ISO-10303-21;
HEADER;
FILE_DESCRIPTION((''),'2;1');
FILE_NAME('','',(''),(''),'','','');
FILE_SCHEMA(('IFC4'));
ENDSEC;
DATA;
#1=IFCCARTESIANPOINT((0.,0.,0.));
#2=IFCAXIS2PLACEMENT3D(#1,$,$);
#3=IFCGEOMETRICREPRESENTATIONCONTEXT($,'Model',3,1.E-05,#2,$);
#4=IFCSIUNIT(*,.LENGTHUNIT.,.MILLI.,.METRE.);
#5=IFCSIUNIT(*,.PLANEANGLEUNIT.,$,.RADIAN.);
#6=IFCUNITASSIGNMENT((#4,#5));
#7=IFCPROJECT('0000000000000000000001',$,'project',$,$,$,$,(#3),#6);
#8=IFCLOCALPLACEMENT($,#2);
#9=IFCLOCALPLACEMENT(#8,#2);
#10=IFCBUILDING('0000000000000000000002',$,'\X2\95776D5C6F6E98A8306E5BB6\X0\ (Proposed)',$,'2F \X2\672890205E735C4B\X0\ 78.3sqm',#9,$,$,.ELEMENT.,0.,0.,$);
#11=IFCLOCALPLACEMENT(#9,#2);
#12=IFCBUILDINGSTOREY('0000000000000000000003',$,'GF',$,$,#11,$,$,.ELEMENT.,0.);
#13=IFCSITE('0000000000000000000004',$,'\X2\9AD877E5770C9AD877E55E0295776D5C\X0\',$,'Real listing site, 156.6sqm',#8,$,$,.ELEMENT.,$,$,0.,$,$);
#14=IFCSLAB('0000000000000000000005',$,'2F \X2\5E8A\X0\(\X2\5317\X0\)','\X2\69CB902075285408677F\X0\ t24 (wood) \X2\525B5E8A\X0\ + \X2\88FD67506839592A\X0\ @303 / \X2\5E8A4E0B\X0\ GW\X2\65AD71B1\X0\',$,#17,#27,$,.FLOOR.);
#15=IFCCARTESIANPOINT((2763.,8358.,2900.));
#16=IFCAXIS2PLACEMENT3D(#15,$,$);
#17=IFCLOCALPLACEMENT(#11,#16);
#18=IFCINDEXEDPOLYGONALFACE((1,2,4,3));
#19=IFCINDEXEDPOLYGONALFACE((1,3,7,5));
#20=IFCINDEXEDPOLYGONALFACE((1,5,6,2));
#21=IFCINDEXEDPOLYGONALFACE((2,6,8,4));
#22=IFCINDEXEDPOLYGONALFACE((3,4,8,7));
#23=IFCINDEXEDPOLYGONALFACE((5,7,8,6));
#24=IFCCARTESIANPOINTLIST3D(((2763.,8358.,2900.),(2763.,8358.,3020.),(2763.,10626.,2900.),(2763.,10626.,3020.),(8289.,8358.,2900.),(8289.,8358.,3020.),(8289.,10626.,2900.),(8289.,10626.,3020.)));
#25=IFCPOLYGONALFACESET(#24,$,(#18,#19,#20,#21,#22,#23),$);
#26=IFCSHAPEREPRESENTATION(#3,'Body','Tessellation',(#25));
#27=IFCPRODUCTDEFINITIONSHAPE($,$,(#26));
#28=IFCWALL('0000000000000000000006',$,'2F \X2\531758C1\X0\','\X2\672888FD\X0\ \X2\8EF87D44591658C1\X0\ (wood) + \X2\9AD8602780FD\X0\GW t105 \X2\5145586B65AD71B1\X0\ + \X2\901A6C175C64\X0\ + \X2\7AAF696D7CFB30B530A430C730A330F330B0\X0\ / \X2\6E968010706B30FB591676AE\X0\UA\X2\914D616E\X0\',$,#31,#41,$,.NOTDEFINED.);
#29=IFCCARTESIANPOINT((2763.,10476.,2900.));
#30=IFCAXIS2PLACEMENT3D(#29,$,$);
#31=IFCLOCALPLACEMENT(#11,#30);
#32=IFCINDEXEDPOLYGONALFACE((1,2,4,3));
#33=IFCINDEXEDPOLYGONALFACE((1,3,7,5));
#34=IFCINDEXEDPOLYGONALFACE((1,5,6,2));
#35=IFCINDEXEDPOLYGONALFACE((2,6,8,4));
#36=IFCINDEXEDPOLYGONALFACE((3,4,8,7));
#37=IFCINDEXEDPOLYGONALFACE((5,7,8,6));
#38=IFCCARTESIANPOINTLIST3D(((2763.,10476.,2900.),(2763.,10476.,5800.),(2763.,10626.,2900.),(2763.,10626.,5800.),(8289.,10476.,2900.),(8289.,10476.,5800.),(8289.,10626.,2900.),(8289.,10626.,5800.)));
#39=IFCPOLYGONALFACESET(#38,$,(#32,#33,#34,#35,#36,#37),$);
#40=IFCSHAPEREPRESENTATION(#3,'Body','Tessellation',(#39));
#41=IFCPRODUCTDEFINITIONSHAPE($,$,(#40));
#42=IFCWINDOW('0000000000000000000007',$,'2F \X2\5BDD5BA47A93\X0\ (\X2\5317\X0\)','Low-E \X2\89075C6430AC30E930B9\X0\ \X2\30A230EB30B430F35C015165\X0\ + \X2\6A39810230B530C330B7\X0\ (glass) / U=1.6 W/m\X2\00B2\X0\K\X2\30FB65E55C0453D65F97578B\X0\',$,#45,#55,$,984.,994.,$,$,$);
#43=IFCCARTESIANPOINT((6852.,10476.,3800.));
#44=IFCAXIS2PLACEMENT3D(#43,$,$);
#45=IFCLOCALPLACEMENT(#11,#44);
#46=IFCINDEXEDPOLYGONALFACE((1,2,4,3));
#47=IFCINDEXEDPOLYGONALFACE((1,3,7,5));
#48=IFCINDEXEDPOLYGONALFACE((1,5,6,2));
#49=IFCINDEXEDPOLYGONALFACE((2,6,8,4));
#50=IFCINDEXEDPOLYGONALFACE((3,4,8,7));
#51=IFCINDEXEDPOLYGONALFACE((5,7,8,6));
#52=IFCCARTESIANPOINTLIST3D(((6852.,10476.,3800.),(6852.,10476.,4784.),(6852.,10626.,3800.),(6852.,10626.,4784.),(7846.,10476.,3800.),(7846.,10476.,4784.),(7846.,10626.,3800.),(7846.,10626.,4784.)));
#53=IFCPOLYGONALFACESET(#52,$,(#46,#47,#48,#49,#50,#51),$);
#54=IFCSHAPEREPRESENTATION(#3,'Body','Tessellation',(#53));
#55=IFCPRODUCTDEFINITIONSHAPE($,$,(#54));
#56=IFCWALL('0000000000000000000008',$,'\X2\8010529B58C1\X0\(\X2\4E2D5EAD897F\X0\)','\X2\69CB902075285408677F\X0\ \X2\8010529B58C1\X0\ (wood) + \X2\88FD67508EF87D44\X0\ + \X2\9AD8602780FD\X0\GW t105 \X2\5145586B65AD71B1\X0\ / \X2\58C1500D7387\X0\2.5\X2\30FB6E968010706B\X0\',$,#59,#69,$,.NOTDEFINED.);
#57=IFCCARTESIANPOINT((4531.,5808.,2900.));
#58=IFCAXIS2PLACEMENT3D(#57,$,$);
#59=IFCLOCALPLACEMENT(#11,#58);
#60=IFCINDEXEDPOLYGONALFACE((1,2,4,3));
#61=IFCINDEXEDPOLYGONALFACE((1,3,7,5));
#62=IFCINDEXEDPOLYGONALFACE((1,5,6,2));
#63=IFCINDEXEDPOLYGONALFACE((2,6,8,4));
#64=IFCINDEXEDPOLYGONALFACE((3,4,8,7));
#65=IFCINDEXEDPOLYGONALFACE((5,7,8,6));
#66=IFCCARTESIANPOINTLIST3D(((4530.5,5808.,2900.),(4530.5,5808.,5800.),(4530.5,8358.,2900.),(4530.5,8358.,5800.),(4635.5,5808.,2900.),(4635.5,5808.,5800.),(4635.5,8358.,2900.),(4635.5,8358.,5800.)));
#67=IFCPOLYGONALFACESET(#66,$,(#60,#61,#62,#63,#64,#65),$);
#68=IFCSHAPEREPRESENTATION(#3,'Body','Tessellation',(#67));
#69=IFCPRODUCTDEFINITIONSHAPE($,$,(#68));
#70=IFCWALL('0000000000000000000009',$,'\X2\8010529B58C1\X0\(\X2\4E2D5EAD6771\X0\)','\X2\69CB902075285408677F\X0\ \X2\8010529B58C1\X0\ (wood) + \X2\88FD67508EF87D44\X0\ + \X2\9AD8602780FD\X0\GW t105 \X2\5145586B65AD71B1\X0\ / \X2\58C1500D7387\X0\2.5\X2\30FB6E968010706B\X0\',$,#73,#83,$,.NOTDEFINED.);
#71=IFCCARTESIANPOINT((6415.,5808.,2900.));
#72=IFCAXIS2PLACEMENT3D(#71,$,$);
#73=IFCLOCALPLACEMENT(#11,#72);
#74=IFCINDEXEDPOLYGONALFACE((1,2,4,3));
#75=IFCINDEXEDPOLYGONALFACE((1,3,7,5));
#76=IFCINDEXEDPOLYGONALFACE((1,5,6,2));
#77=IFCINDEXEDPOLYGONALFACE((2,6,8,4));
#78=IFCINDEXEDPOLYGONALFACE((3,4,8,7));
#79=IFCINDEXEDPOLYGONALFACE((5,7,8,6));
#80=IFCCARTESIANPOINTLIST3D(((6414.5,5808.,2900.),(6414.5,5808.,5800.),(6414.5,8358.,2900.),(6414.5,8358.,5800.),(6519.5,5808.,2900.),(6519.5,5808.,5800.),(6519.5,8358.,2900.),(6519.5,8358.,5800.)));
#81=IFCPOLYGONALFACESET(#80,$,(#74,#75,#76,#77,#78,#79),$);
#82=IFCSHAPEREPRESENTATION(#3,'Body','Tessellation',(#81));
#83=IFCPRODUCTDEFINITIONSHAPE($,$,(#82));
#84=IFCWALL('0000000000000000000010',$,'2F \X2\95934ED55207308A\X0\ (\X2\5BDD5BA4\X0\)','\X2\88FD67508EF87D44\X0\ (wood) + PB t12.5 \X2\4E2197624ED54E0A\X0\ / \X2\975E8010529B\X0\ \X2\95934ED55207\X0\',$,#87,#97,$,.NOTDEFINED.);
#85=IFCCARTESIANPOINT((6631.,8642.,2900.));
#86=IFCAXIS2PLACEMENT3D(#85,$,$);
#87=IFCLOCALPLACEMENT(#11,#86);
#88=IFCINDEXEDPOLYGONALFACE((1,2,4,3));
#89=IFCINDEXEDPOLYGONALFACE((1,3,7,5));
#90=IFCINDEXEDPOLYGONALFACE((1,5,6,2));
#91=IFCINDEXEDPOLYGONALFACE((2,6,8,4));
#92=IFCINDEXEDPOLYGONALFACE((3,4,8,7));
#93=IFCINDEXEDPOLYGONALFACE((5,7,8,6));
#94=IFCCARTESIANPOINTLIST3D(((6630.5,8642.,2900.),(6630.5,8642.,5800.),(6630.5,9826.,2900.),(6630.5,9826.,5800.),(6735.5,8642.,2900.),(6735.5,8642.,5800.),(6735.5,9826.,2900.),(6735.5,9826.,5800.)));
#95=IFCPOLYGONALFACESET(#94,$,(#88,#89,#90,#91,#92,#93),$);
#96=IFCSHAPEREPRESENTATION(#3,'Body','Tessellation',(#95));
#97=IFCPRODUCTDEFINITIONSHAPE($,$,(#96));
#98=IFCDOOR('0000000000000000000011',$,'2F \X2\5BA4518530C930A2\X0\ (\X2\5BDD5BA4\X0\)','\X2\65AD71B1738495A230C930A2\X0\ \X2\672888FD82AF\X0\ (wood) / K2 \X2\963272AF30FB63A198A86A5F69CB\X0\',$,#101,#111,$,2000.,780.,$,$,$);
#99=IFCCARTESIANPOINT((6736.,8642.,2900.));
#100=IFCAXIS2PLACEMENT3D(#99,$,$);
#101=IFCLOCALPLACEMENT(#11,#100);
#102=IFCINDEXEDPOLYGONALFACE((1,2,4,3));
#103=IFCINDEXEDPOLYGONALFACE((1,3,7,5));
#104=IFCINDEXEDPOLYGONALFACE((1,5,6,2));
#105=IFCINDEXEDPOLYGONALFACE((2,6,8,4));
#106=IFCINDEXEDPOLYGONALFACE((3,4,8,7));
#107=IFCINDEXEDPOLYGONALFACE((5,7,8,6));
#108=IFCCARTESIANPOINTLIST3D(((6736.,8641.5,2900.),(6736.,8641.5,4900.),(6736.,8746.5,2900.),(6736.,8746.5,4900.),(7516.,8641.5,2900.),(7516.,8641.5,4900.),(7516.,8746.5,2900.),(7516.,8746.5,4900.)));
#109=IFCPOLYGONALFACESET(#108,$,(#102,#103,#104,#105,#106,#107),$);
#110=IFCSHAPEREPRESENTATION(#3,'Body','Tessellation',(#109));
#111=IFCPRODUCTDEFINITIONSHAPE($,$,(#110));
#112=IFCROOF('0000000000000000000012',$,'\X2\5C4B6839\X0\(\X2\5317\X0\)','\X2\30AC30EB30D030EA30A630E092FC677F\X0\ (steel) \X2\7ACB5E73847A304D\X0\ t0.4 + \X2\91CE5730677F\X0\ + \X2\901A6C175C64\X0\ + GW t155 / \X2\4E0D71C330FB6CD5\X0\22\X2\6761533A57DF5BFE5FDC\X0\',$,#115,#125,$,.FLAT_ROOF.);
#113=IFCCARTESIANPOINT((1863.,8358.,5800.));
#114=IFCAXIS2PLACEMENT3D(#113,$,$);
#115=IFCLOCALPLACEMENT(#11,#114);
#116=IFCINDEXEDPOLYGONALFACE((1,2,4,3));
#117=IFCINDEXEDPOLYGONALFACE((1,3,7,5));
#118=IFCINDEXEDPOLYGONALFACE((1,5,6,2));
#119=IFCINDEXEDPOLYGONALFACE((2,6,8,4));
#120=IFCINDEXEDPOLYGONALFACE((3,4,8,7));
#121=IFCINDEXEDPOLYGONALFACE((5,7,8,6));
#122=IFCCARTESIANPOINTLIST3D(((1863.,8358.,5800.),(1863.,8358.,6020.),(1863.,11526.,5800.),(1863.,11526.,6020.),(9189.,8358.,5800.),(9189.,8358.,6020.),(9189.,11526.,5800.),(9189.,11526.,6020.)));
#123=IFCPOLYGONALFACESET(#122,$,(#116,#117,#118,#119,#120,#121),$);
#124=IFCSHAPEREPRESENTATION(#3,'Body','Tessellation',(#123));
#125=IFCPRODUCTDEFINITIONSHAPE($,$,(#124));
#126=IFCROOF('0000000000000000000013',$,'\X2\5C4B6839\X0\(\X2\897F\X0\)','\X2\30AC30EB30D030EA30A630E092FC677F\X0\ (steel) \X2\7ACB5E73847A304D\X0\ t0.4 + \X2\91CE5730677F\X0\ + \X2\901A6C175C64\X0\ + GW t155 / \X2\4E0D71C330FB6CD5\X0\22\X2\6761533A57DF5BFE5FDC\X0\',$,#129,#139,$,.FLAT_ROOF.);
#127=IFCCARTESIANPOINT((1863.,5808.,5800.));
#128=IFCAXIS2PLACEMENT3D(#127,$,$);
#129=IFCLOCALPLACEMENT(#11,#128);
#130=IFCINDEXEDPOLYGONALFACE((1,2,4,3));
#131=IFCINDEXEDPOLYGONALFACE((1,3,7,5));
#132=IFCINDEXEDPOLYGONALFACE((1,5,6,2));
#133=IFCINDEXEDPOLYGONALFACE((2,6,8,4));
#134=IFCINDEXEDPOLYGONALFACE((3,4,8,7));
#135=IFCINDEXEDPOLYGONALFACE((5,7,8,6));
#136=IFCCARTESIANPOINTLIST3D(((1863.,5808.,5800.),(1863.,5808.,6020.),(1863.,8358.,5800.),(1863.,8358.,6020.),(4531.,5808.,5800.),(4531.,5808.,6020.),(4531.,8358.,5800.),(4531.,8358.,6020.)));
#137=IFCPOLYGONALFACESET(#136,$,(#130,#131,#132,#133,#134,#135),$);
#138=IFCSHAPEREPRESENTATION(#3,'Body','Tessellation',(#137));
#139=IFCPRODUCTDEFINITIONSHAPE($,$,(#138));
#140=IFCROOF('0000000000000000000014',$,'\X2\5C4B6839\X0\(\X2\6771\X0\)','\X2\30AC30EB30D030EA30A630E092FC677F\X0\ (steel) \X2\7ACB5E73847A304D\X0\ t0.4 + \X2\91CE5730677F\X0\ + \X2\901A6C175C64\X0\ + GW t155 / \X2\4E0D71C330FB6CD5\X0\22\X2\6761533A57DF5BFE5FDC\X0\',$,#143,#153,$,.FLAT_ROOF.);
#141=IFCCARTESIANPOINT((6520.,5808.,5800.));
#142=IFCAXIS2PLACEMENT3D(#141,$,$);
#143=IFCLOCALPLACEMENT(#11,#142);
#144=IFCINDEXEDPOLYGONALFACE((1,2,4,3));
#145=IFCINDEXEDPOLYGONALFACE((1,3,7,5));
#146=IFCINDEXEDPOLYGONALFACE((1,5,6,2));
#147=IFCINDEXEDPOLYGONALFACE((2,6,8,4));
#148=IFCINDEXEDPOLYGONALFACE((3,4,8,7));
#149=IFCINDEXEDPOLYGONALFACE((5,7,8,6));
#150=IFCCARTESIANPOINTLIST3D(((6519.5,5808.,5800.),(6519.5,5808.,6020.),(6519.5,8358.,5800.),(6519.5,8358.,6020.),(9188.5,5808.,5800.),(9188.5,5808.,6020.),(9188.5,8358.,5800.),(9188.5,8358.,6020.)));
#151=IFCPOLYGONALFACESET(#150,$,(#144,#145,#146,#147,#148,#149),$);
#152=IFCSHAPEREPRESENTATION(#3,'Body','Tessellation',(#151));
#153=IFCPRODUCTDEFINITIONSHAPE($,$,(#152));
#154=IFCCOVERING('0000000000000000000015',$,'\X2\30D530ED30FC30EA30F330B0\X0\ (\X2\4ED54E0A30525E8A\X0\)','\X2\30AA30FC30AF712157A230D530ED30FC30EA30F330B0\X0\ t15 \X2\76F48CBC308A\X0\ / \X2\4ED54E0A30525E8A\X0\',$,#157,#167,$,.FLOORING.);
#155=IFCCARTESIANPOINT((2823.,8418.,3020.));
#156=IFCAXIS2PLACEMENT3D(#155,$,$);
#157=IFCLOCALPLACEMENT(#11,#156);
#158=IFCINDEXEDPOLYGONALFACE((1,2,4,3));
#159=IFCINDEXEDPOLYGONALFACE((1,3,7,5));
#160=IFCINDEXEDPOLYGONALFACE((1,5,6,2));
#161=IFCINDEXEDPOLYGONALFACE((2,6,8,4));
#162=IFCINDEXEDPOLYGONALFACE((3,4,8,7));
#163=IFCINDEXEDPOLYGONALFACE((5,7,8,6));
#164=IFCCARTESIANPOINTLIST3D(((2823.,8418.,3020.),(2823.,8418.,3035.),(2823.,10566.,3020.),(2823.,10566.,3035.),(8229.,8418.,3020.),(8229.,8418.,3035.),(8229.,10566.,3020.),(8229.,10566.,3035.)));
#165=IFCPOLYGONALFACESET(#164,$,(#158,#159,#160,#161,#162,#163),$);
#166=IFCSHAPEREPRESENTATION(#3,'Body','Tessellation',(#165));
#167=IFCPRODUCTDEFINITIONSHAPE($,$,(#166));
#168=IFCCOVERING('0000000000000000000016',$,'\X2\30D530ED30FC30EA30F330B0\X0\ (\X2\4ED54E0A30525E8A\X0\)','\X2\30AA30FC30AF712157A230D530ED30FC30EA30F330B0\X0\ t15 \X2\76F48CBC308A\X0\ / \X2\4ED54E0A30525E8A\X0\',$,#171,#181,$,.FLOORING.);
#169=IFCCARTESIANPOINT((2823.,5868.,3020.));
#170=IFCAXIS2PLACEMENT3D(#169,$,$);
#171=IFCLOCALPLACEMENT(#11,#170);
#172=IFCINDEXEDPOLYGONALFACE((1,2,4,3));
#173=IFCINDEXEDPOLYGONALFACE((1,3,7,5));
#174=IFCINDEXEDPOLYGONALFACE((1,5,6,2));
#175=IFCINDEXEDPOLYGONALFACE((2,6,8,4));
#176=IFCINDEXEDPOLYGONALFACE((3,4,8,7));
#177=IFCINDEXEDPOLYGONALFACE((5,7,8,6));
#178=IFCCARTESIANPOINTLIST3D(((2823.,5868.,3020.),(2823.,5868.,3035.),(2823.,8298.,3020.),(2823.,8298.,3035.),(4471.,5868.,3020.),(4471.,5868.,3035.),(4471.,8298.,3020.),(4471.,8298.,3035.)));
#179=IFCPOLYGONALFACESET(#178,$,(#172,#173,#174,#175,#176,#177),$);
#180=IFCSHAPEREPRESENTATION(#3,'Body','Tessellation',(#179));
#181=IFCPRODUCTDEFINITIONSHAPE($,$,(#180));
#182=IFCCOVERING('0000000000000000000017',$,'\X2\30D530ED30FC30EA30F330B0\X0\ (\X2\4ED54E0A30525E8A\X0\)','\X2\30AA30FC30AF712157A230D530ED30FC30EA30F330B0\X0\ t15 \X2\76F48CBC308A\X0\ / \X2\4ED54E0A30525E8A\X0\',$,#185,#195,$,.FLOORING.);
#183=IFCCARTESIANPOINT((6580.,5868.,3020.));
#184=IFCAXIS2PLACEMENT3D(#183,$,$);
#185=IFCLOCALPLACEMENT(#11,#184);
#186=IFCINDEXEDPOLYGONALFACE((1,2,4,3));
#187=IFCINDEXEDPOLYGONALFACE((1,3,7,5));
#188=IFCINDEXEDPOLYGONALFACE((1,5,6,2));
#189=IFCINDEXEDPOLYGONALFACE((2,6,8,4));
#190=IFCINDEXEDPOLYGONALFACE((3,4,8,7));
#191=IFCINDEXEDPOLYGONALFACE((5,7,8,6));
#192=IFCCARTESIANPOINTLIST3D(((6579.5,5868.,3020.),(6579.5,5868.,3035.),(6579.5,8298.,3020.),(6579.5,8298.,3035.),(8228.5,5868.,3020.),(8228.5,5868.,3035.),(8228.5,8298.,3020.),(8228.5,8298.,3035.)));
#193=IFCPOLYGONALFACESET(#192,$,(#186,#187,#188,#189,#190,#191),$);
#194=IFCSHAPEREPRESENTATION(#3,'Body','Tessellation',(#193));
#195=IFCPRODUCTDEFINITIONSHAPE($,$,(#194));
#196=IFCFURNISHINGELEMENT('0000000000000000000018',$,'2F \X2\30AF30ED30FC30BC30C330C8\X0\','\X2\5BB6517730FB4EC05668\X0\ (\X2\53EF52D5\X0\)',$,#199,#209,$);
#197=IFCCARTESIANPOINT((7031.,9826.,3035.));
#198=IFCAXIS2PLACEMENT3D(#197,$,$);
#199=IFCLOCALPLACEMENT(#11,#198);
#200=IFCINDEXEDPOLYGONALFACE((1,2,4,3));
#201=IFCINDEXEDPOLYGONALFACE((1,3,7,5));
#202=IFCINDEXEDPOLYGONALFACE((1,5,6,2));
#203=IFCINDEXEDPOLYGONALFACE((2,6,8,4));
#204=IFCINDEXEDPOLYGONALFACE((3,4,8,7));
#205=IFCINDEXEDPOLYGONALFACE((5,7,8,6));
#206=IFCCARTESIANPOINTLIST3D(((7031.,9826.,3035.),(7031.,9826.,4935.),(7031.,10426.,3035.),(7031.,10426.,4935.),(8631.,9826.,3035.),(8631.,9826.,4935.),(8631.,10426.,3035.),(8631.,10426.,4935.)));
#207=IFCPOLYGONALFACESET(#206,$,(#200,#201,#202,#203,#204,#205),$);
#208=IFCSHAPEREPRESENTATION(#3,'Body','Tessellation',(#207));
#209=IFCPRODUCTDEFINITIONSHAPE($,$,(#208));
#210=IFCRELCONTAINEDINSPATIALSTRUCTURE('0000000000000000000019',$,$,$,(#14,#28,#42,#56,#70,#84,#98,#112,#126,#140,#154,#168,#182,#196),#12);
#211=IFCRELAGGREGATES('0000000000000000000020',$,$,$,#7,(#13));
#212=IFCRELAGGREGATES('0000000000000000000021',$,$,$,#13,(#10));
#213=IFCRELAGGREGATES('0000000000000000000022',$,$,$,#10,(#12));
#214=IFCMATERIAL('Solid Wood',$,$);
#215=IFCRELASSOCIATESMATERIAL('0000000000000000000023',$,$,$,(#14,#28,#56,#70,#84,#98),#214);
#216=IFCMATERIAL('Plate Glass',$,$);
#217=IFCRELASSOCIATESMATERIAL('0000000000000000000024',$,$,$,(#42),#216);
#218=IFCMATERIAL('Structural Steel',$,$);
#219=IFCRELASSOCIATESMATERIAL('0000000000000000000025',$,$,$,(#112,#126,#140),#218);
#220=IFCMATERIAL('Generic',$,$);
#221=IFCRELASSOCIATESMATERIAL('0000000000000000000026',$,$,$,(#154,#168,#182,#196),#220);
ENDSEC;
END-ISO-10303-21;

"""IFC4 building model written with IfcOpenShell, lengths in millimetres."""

from ifc_helpers import new_model, si_unit, frame, frame_2d, origin, place, context, project, spatial, rectangle, extrude, material, element, fill, save


model = new_model("IFC4")

# Units and contexts
model_context = context("Model", 3, precision=1e-05, world=origin())
ifc_project = project(units=[si_unit("LENGTHUNIT", "METRE", prefix="MILLI"), si_unit("PLANEANGLEUNIT", "RADIAN")], contexts=[model_context])

# Site, building, storey
site_placement = place(None, origin())
site = spatial("IfcSite", under=ifc_project, at=site_placement, Name="高知県高知市長浜", ObjectType="Real listing site, 156.6sqm", CompositionType="ELEMENT", RefElevation=0.0)
building_placement = place(site_placement, origin())
building = spatial("IfcBuilding", under=site, at=building_placement, Name="長浜潮風の家 (Proposed)", ObjectType="2F 木造平屋 78.3sqm", CompositionType="ELEMENT", ElevationOfRefHeight=0.0, ElevationOfTerrain=0.0)
storey_placement = place(building_placement, origin())
storey = spatial("IfcBuildingStorey", under=building, at=storey_placement, Name="GF", CompositionType="ELEMENT", Elevation=0.0)

# Slab
ifc_material_1 = material(Name="Solid Wood")
slab_placement = place(storey_placement, frame((2763.0, 8358.0, 2900.0)))
element("IfcSlab", 1, at=slab_placement, inside=storey, material=ifc_material_1, Name="2F 床(北)", Description="構造用合板 t24 (wood) 剛床 + 製材根太 @303 / 床下 GW断熱", PredefinedType="FLOOR", context=model_context, shape_type="SweptSolid", body=[
    extrude(rectangle(XDim=5526.0, YDim=2268.0, at=frame_2d((2763.0, 1134.0))), frame((2763.0, 8358.0, 2900.0)), (0.0, 0.0, 1.0), 120.0),
])

# Wall, opening, window
wall_1_placement = place(storey_placement, frame((2763.0, 10476.0, 2900.0)))
wall_1 = element("IfcWall", 2, at=wall_1_placement, inside=storey, material=ifc_material_1, Name="2F 北壁", Description="木製 軸組外壁 (wood) + 高性能GW t105 充填断熱 + 通気層 + 窯業系サイディング / 準耐火・外皮UA配慮", PredefinedType="NOTDEFINED", context=model_context, shape_type="SweptSolid", body=[
    extrude(rectangle(XDim=5526.0, YDim=150.0, at=frame_2d((2763.0, 75.0))), frame((2763.0, 10476.0, 2900.0)), (0.0, 0.0, 1.0), 2900.0),
])
opening_1_placement = place(storey_placement, frame((6852.0, 10476.0, 3800.0)))
opening_1 = element("IfcOpeningElement", 3, at=opening_1_placement, cuts=wall_1, PredefinedType="NOTDEFINED", context=model_context, shape_type="SweptSolid", body=[
    extrude(rectangle(XDim=994.0, YDim=150.0, at=frame_2d((497.0, 75.0))), frame((6852.0, 10476.0, 3800.0)), (0.0, 0.0, 1.0), 984.0),
])
ifc_material_2 = material(Name="Plate Glass")
window_1_placement = place(storey_placement, frame((6852.0, 10476.0, 3800.0)))
window_1 = element("IfcWindow", 4, at=window_1_placement, inside=storey, material=ifc_material_2, Name="2F 寝室窓 (北)", Description="Low-E 複層ガラス アルゴン封入 + 樹脂サッシ (glass) / U=1.6 W/m²K・日射取得型", OverallHeight=984.0, OverallWidth=994.0, context=model_context, shape_type="SweptSolid", body=[
    extrude(rectangle(XDim=994.0, YDim=150.0, at=frame_2d((497.0, 75.0))), frame((6852.0, 10476.0, 3800.0)), (0.0, 0.0, 1.0), 984.0),
])
fill(opening_1, window_1)

# Walls
wall_2_placement = place(storey_placement, frame((4531.0, 5808.0, 2900.0)))
element("IfcWall", 5, at=wall_2_placement, inside=storey, material=ifc_material_1, Name="耐力壁(中庭西)", Description="構造用合板 耐力壁 (wood) + 製材軸組 + 高性能GW t105 充填断熱 / 壁倍率2.5・準耐火", PredefinedType="NOTDEFINED", context=model_context, shape_type="SweptSolid", body=[
    extrude(rectangle(XDim=105.0, YDim=2550.0, at=frame_2d((52.0, 1275.0))), frame((4531.0, 5808.0, 2900.0)), (0.0, 0.0, 1.0), 2900.0),
])
wall_3_placement = place(storey_placement, frame((6415.0, 5808.0, 2900.0)))
element("IfcWall", 6, at=wall_3_placement, inside=storey, material=ifc_material_1, Name="耐力壁(中庭東)", Description="構造用合板 耐力壁 (wood) + 製材軸組 + 高性能GW t105 充填断熱 / 壁倍率2.5・準耐火", PredefinedType="NOTDEFINED", context=model_context, shape_type="SweptSolid", body=[
    extrude(rectangle(XDim=105.0, YDim=2550.0, at=frame_2d((52.0, 1275.0))), frame((6415.0, 5808.0, 2900.0)), (0.0, 0.0, 1.0), 2900.0),
])
wall_4_placement = place(storey_placement, frame((6631.0, 8642.0, 2900.0)))
element("IfcWall", 7, at=wall_4_placement, inside=storey, material=ifc_material_1, Name="2F 間仕切り (寝室)", Description="製材軸組 (wood) + PB t12.5 両面仕上 / 非耐力 間仕切", PredefinedType="NOTDEFINED", context=model_context, shape_type="SweptSolid", body=[
    extrude(rectangle(XDim=105.0, YDim=1184.0, at=frame_2d((52.0, 592.0))), frame((6631.0, 8642.0, 2900.0)), (0.0, 0.0, 1.0), 2900.0),
])

# Door
door_placement = place(storey_placement, frame((6736.0, 8642.0, 2900.0)))
element("IfcDoor", 8, at=door_placement, inside=storey, material=ifc_material_1, Name="2F 室内ドア (寝室)", Description="断熱玄関ドア 木製芯 (wood) / K2 防犯・採風機構", OverallHeight=2000.0, OverallWidth=780.0, context=model_context, shape_type="SweptSolid", body=[
    extrude(rectangle(XDim=780.0, YDim=105.0, at=frame_2d((390.0, 52.0))), frame((6736.0, 8642.0, 2900.0)), (0.0, 0.0, 1.0), 2000.0),
])

# Roofs
ifc_material_3 = material(Name="Structural Steel")
for number, where, name in (
    (9, (1863.0, 8358.0, 5800.0), "屋根(北)"),
):
    element("IfcRoof", number, at=place(storey_placement, frame(where)), inside=storey, material=ifc_material_3, Name=name, Description="ガルバリウム鋼板 (steel) 立平葺き t0.4 + 野地板 + 通気層 + GW t155 / 不燃・法22条区域対応", PredefinedType="FLAT_ROOF", context=model_context, shape_type="SweptSolid", body=[
        extrude(rectangle(XDim=7326.0, YDim=3168.0, at=frame_2d((3663.0, 1584.0))), frame((1863.0, 8358.0, 5800.0)), (0.0, 0.0, 1.0), 220.0),
    ])
roof_1_placement = place(storey_placement, frame((1863.0, 5808.0, 5800.0)))
element("IfcRoof", 10, at=roof_1_placement, inside=storey, material=ifc_material_3, Name="屋根(西)", Description="ガルバリウム鋼板 (steel) 立平葺き t0.4 + 野地板 + 通気層 + GW t155 / 不燃・法22条区域対応", PredefinedType="FLAT_ROOF", context=model_context, shape_type="SweptSolid", body=[
    extrude(rectangle(XDim=2668.0, YDim=2550.0, at=frame_2d((1334.0, 1275.0))), frame((1863.0, 5808.0, 5800.0)), (0.0, 0.0, 1.0), 220.0),
])
roof_2_placement = place(storey_placement, frame((6520.0, 5808.0, 5800.0)))
element("IfcRoof", 11, at=roof_2_placement, inside=storey, material=ifc_material_3, Name="屋根(東)", Description="ガルバリウム鋼板 (steel) 立平葺き t0.4 + 野地板 + 通気層 + GW t155 / 不燃・法22条区域対応", PredefinedType="FLAT_ROOF", context=model_context, shape_type="SweptSolid", body=[
    extrude(rectangle(XDim=2669.0, YDim=2550.0, at=frame_2d((1334.0, 1275.0))), frame((6520.0, 5808.0, 5800.0)), (0.0, 0.0, 1.0), 220.0),
])

# Coverings
ifc_material_4 = material(Name="Generic")
covering_1_placement = place(storey_placement, frame((2823.0, 8418.0, 3020.0)))
element("IfcCovering", 12, at=covering_1_placement, inside=storey, material=ifc_material_4, Name="フローリング (仕上げ床)", Description="オーク無垢フローリング t15 直貼り / 仕上げ床", PredefinedType="FLOORING", context=model_context, shape_type="SweptSolid", body=[
    extrude(rectangle(XDim=5406.0, YDim=2148.0, at=frame_2d((2703.0, 1074.0))), frame((2823.0, 8418.0, 3020.0)), (0.0, 0.0, 1.0), 15.0),
])
covering_2_placement = place(storey_placement, frame((2823.0, 5868.0, 3020.0)))
element("IfcCovering", 13, at=covering_2_placement, inside=storey, material=ifc_material_4, Name="フローリング (仕上げ床)", Description="オーク無垢フローリング t15 直貼り / 仕上げ床", PredefinedType="FLOORING", context=model_context, shape_type="SweptSolid", body=[
    extrude(rectangle(XDim=1648.0, YDim=2430.0, at=frame_2d((824.0, 1215.0))), frame((2823.0, 5868.0, 3020.0)), (0.0, 0.0, 1.0), 15.0),
])
covering_3_placement = place(storey_placement, frame((6580.0, 5868.0, 3020.0)))
element("IfcCovering", 14, at=covering_3_placement, inside=storey, material=ifc_material_4, Name="フローリング (仕上げ床)", Description="オーク無垢フローリング t15 直貼り / 仕上げ床", PredefinedType="FLOORING", context=model_context, shape_type="SweptSolid", body=[
    extrude(rectangle(XDim=1649.0, YDim=2430.0, at=frame_2d((824.0, 1215.0))), frame((6580.0, 5868.0, 3020.0)), (0.0, 0.0, 1.0), 15.0),
])

# Furnishing element
furnishing_1_placement = place(storey_placement, frame((7031.0, 9826.0, 3035.0)))
element("IfcFurnishingElement", 15, at=furnishing_1_placement, inside=storey, material=ifc_material_4, Name="2F クローゼット", Description="家具・什器 (可動)", context=model_context, shape_type="SweptSolid", body=[
    extrude(rectangle(XDim=1600.0, YDim=600.0, at=frame_2d((800.0, 300.0))), frame((7031.0, 9826.0, 3035.0)), (0.0, 0.0, 1.0), 1900.0),
])

save(model, "model.ifc")
